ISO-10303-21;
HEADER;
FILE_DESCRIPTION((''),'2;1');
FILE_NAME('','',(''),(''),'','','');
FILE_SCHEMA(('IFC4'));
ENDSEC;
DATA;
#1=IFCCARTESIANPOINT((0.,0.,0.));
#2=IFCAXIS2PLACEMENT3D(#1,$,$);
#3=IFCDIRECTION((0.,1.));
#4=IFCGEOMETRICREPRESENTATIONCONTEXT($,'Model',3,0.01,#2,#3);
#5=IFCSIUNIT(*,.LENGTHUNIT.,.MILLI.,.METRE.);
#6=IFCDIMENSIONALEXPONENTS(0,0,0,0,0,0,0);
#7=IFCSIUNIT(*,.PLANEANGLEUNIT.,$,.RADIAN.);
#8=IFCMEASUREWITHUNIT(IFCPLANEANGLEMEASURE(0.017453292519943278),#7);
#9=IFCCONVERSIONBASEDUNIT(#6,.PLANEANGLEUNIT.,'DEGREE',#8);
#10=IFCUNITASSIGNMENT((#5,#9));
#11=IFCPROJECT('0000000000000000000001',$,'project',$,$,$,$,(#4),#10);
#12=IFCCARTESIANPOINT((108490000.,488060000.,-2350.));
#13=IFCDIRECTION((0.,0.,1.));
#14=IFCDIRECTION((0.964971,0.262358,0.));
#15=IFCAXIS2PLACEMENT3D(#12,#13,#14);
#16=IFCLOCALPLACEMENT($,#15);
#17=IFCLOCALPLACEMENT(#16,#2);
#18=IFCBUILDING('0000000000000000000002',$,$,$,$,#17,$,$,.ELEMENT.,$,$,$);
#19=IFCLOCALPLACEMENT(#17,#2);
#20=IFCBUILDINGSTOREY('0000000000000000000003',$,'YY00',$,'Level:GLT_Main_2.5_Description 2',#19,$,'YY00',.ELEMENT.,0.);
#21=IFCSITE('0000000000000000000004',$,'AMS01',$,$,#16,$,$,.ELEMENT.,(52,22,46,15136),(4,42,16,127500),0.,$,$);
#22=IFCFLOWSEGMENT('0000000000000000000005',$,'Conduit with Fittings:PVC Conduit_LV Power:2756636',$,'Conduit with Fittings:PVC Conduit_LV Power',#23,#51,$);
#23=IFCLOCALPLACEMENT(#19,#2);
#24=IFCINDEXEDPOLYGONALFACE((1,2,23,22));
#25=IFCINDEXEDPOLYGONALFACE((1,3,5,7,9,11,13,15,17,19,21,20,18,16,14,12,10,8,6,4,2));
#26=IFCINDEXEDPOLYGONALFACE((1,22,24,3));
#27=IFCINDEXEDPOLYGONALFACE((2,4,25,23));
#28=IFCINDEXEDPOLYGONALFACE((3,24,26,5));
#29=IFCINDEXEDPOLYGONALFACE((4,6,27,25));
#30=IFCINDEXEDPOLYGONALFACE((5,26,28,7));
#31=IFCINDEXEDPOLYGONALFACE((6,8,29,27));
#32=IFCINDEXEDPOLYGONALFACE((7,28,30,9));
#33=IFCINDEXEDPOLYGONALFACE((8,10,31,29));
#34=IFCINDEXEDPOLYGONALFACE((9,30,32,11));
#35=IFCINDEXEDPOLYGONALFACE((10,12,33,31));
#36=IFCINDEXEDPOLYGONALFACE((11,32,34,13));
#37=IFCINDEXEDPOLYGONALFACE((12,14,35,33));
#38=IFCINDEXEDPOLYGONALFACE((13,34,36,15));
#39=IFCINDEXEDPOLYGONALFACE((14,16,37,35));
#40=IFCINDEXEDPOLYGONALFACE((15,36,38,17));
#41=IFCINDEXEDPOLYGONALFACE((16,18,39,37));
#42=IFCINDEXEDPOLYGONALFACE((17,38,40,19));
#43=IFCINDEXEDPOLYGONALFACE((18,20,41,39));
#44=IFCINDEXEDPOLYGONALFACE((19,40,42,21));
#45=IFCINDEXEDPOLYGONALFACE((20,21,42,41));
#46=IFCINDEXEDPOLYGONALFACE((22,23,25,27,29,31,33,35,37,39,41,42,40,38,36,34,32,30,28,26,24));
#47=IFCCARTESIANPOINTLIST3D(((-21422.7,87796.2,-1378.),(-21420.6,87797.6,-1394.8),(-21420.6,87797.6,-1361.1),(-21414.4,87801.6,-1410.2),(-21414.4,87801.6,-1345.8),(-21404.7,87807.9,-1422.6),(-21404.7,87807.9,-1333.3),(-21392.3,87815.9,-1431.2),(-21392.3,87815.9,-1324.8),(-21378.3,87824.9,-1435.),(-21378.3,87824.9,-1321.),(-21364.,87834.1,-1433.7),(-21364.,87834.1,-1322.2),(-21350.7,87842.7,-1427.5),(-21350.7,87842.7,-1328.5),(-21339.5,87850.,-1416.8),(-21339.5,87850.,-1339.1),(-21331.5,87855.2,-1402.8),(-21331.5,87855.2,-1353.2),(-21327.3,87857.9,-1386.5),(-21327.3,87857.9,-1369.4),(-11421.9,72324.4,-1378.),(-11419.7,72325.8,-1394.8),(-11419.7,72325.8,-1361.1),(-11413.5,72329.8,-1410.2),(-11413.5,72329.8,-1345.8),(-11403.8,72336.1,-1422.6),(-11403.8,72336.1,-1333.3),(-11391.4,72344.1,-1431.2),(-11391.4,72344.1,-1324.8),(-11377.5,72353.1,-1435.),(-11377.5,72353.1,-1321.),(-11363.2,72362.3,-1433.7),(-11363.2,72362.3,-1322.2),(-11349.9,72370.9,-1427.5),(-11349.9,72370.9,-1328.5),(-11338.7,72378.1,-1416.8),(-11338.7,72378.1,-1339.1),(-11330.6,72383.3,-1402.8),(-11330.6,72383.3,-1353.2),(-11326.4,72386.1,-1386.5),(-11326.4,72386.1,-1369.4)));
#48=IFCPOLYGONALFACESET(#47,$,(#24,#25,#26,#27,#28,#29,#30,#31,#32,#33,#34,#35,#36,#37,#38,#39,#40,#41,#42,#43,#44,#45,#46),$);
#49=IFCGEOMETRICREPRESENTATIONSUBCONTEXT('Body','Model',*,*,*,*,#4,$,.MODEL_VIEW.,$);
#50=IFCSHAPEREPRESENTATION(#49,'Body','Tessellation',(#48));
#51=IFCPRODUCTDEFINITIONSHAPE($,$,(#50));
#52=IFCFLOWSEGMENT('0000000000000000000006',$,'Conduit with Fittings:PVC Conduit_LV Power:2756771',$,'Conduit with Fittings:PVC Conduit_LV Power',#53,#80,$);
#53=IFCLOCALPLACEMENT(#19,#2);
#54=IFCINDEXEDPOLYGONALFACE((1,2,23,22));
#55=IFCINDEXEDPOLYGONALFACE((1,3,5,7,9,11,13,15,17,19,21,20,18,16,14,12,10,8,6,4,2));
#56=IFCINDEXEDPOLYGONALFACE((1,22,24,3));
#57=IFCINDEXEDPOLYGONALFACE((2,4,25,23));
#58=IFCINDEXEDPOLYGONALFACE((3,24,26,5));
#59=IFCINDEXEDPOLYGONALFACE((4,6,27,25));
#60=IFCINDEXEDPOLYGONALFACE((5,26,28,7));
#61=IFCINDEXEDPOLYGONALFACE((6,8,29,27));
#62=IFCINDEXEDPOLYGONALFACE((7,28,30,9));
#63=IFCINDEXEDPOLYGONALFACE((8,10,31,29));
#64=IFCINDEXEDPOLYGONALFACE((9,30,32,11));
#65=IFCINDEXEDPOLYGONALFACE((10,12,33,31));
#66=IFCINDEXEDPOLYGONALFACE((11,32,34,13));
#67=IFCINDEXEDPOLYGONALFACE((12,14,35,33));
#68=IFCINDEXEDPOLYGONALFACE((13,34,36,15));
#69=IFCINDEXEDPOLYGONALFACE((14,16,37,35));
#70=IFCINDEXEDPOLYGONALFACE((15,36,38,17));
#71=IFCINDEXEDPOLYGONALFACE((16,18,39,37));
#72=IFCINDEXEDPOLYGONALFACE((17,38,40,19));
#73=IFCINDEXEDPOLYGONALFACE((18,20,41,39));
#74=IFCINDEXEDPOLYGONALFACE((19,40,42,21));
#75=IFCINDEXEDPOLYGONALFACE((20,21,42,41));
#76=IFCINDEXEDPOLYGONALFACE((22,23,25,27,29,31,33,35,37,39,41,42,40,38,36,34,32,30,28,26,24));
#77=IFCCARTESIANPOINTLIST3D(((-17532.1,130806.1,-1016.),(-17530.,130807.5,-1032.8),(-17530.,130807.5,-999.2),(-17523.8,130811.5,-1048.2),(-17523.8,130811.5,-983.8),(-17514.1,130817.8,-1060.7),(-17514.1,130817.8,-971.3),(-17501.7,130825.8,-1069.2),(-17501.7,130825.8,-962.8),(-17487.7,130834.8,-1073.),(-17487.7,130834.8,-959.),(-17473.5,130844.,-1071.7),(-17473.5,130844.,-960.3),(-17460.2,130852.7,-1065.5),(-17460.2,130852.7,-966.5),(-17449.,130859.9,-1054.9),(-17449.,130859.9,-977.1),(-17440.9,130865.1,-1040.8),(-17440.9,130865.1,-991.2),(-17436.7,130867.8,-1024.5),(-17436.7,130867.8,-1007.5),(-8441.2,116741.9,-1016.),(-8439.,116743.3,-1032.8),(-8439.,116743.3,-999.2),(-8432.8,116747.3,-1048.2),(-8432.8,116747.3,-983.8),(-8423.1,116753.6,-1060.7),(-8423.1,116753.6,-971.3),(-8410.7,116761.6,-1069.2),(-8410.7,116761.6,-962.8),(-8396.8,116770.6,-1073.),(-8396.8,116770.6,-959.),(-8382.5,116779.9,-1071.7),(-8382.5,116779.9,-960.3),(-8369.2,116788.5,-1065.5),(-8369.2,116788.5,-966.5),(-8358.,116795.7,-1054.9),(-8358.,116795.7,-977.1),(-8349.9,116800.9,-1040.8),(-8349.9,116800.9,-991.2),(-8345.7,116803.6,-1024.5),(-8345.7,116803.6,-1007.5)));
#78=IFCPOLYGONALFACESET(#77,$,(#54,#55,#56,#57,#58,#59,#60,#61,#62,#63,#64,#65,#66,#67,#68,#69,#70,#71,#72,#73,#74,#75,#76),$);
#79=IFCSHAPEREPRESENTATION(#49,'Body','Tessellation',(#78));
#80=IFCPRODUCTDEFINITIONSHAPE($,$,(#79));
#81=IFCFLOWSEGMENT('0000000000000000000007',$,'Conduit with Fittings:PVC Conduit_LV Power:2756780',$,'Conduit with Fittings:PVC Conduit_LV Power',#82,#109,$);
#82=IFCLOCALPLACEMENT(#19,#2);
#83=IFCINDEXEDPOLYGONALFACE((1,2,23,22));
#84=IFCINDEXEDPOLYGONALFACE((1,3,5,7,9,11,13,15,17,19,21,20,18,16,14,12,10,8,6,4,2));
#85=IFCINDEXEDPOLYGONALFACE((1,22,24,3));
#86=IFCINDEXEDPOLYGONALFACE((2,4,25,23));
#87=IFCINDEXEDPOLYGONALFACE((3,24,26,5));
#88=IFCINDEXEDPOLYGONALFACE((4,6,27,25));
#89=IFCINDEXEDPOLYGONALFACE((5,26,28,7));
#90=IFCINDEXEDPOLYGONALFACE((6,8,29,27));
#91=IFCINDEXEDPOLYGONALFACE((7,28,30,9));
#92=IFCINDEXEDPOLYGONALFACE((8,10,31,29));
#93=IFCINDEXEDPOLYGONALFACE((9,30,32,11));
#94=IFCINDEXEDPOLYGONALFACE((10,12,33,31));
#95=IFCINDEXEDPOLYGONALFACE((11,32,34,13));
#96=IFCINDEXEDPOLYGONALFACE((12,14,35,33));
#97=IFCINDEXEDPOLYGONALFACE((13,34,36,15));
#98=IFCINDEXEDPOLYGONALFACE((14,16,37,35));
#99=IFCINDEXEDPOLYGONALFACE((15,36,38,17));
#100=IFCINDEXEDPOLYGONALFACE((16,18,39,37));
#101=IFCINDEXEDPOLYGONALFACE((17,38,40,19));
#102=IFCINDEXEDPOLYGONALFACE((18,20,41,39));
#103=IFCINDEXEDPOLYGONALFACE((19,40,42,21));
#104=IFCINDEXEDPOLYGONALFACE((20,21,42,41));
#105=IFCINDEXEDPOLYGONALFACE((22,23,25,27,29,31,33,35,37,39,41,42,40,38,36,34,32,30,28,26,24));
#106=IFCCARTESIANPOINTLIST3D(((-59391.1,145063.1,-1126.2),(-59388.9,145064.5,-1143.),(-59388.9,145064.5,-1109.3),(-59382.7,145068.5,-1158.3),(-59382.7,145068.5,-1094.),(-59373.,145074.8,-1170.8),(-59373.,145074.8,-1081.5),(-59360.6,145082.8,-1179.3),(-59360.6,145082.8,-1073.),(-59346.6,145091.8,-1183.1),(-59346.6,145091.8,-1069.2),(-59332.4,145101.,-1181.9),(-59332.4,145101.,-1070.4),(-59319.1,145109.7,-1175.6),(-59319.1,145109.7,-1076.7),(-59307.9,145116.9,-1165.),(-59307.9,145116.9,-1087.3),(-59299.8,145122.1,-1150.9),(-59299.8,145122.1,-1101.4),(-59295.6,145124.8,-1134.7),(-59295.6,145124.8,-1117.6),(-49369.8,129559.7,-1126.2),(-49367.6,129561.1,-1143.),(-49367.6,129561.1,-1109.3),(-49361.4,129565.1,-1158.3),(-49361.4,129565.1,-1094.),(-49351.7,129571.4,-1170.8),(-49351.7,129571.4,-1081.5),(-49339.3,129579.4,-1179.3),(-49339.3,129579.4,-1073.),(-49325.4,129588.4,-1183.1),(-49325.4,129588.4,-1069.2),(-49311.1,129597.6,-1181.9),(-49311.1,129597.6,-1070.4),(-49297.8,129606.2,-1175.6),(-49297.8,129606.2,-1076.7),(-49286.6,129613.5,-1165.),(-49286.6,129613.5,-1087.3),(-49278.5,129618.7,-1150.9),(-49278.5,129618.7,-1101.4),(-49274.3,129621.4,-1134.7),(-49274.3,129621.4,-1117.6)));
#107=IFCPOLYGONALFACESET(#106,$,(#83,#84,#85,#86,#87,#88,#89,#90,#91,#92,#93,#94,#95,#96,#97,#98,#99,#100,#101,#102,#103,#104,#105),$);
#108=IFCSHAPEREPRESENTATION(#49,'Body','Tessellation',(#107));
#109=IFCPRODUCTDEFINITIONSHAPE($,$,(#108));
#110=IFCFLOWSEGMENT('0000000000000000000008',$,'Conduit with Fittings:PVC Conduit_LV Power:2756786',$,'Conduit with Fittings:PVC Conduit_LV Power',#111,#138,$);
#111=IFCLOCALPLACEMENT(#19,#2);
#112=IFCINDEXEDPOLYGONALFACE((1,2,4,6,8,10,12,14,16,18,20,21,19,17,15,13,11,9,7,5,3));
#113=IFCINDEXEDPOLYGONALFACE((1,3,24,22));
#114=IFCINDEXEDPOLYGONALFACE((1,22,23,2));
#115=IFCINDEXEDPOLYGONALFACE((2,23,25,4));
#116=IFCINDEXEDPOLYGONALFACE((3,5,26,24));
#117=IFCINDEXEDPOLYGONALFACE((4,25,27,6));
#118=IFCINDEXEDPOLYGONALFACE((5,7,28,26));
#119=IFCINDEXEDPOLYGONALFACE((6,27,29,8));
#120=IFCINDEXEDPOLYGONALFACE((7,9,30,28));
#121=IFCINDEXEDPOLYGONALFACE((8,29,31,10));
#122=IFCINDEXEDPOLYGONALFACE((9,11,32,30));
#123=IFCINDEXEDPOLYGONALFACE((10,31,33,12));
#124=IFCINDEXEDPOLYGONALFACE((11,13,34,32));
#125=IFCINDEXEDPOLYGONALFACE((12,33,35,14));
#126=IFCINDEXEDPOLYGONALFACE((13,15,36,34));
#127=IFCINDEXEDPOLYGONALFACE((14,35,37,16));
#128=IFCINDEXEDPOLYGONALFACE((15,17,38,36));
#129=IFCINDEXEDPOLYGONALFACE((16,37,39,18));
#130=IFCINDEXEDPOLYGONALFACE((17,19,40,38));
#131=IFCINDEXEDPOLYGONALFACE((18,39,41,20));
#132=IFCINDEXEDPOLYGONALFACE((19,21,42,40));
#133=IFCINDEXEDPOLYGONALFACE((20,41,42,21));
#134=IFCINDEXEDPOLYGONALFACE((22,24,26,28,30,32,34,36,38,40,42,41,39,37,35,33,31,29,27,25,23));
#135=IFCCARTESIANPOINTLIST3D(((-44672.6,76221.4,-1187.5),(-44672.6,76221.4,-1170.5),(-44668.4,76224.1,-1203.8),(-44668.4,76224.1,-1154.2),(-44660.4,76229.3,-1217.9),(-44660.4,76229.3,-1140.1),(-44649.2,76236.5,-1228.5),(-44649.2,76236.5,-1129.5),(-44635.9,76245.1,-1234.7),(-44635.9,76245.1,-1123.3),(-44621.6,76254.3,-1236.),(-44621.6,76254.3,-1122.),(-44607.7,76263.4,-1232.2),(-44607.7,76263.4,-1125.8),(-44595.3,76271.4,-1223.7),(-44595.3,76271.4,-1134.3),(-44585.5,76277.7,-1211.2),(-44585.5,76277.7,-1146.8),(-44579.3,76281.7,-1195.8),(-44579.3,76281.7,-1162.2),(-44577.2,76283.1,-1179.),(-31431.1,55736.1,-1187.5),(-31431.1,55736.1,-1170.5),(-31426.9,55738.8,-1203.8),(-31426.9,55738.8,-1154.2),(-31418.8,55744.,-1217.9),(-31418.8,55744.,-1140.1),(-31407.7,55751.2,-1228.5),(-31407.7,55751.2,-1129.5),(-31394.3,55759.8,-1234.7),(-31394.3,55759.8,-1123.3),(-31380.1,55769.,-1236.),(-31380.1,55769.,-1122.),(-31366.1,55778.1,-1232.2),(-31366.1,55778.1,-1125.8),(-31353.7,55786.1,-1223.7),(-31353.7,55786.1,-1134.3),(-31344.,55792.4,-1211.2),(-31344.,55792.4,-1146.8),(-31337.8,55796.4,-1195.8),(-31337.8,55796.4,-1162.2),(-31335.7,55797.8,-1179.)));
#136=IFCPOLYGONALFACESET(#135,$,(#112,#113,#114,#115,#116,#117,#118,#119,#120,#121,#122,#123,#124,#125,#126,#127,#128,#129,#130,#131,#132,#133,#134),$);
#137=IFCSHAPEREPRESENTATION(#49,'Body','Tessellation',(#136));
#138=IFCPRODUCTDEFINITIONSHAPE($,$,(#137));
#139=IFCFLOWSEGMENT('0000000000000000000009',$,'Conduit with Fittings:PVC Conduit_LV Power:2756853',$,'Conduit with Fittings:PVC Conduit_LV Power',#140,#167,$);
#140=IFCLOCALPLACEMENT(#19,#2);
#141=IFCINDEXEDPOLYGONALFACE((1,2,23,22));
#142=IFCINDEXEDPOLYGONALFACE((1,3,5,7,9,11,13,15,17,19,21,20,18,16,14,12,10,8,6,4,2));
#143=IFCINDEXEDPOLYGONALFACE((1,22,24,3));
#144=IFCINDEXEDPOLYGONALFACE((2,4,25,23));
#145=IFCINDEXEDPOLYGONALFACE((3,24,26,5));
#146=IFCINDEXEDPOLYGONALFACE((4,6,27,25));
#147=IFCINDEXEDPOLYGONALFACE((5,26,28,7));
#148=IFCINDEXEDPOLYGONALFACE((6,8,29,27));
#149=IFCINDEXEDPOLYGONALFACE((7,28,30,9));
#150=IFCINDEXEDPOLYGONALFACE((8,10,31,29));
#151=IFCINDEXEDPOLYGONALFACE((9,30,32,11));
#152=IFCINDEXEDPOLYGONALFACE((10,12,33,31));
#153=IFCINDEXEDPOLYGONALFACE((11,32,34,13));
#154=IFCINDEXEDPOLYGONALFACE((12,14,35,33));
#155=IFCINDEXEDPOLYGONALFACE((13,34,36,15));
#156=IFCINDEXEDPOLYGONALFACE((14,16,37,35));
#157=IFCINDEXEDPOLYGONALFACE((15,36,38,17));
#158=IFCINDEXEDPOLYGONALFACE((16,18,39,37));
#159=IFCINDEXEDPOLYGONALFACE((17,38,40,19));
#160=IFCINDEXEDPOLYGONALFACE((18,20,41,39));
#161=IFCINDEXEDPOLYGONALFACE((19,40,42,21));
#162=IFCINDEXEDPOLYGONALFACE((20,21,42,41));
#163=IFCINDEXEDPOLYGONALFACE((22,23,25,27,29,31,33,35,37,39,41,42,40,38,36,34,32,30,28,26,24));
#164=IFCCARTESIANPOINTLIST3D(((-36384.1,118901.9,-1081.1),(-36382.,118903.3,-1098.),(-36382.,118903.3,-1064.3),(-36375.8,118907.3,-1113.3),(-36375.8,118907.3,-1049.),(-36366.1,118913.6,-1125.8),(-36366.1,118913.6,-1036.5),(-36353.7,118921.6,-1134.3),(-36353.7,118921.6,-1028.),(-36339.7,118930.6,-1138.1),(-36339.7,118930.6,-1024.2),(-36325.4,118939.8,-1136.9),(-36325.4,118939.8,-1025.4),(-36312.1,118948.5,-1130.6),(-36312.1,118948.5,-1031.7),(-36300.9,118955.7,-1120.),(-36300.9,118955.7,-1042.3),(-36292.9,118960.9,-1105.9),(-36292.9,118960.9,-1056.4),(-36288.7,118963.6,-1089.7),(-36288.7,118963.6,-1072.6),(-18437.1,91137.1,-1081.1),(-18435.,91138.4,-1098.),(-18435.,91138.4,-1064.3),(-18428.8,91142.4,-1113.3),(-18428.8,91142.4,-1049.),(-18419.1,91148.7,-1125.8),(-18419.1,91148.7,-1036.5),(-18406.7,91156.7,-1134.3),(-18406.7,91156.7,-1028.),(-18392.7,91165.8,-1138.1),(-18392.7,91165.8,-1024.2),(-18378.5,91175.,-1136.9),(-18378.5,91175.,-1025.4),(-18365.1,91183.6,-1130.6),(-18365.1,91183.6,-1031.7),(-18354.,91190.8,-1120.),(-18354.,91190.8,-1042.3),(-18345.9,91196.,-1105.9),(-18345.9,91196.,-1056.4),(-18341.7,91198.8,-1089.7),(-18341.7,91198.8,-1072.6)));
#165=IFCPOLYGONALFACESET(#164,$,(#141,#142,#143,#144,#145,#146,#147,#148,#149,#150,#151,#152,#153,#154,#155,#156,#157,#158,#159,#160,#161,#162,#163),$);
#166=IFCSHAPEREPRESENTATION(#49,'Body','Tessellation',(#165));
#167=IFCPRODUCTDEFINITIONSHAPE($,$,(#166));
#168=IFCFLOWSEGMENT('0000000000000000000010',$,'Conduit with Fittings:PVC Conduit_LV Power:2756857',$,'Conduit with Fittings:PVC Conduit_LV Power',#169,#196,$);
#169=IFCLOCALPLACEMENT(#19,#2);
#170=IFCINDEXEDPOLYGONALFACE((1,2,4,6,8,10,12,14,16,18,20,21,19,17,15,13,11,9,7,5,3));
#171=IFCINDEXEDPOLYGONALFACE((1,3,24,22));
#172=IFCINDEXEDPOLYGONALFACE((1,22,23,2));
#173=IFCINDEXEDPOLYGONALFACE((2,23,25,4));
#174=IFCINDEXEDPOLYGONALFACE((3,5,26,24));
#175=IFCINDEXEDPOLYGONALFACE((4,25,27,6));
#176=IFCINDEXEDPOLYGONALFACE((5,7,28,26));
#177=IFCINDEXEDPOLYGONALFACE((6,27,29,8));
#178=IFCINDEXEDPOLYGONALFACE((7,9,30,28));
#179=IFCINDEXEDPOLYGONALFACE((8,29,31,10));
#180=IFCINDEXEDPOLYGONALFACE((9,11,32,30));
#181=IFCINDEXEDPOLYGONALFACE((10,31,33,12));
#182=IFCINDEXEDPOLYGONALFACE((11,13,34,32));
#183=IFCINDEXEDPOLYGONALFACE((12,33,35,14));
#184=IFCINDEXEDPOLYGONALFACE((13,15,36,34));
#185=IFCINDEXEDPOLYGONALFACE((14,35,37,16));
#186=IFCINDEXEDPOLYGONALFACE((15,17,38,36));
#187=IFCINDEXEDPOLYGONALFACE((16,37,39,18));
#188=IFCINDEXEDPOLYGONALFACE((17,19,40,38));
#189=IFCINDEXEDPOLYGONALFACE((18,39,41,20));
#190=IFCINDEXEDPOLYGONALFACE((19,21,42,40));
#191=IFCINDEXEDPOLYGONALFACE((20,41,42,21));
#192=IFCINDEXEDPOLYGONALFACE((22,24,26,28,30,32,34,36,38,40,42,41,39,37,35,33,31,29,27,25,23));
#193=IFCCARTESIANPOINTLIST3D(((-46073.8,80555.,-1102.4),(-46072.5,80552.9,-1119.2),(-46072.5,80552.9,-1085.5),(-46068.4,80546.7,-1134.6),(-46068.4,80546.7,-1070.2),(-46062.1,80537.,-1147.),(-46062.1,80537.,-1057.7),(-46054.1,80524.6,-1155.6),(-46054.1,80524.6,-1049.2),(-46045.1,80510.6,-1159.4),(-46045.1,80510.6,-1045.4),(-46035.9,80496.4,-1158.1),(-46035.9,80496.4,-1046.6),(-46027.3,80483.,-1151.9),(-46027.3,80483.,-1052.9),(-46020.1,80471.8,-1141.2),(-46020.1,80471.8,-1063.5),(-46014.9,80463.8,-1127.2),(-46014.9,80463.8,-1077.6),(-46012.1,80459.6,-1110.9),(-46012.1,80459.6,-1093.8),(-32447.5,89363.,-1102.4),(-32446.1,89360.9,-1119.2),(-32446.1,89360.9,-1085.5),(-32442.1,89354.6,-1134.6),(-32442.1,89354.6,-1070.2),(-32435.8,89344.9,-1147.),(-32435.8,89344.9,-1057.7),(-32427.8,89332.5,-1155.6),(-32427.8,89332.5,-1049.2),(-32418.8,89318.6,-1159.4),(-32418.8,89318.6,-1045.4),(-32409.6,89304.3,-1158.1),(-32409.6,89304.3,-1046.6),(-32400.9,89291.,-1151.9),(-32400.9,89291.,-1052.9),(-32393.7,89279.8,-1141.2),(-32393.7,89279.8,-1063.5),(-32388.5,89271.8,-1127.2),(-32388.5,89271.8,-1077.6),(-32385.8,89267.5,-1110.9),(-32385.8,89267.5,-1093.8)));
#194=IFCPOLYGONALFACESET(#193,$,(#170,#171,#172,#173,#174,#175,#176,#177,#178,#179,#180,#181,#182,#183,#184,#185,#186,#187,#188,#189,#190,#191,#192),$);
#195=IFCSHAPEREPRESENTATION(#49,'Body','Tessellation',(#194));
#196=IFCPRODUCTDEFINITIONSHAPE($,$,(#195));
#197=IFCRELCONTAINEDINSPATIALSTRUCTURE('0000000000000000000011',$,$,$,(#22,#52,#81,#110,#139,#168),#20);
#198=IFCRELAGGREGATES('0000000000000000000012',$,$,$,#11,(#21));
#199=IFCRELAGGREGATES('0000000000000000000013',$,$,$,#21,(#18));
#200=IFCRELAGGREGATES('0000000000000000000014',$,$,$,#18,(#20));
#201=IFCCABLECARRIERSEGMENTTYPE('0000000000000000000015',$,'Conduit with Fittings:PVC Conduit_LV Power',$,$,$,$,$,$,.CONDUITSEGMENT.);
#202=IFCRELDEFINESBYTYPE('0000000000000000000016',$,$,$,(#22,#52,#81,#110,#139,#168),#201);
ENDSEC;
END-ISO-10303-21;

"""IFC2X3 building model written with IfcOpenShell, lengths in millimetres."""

from ifc_helpers import new_model, entity, si_unit, converted_unit, direction, frame, frame_2d, origin, origin_2d_with_axis, place, context, subcontext, project, spatial, circle, extrude, type_object, element, save


model = new_model("IFC2X3")

# Units and contexts
model_context = context("Model", 3, precision=0.01, world=origin(), true_north=direction((0.0, 1.0)))
body_context = subcontext(model_context, "Body", "Model", "MODEL_VIEW")
ifc_project = project(units=[si_unit("LENGTHUNIT", "METRE", prefix="MILLI"), converted_unit("PLANEANGLEUNIT", "DEGREE", entity("IfcPlaneAngleMeasure", 0.017453292519943278), si_unit("PLANEANGLEUNIT", "RADIAN"), dimensions=[0, 0, 0, 0, 0, 0, 0])], contexts=[model_context])

# Site, building, storey
site_placement = place(None, frame((108490000.0, 488060000.0, -2350.0), z_axis=(0.0, 0.0, 1.0), x_axis=(0.964971, 0.262358, 0.0)))
site = spatial("IfcSite", under=ifc_project, at=site_placement, Name="AMS01", CompositionType="ELEMENT", RefLatitude=(52, 22, 46, 15136), RefLongitude=(4, 42, 16, 127500), RefElevation=0.0)
building_placement = place(site_placement, origin())
building = spatial("IfcBuilding", under=site, at=building_placement, CompositionType="ELEMENT")
storey_placement = place(building_placement, origin())
storey = spatial("IfcBuildingStorey", under=building, at=storey_placement, Name="YY00", ObjectType="Level:GLT_Main_2.5_Description 2", LongName="YY00", CompositionType="ELEMENT", Elevation=0.0)

# Flow segments
cable_carrier_segment_type = type_object("IfcCableCarrierSegmentType", Name="Conduit with Fittings:PVC Conduit_LV Power", PredefinedType="CONDUITSEGMENT")
flow_segment_1_placement = place(storey_placement, origin())
element("IfcFlowSegment", 1, at=flow_segment_1_placement, inside=storey, type_object=cable_carrier_segment_type, Name="Conduit with Fittings:PVC Conduit_LV Power:2756636", ObjectType="Conduit with Fittings:PVC Conduit_LV Power", context=body_context, shape_type="SweptSolid", body=[
    extrude(circle(Radius=57.2, at=origin_2d_with_axis()), frame((-21374.7, 87827.2, -1378.0), z_axis=(0.542856, -0.839826, 0.0), x_axis=(-0.839826, -0.542856, 0.0)), (0.0, 0.0, 1.0), 18422.7),
])
flow_segment_2_placement = place(storey_placement, origin())
element("IfcFlowSegment", 2, at=flow_segment_2_placement, inside=storey, type_object=cable_carrier_segment_type, Name="Conduit with Fittings:PVC Conduit_LV Power:2756771", ObjectType="Conduit with Fittings:PVC Conduit_LV Power", context=body_context, shape_type="SweptSolid", body=[
    extrude(circle(Radius=57.2, at=frame_2d((0.0, 0.0), x_axis=(1.0, 0.0))), frame((-8393.2, 116773.0, -1016.0), z_axis=(-0.542856, 0.839826, 0.0), x_axis=(-0.839826, -0.542856, 0.0)), (0.0, 0.0, 1.0), 16746.6),
])
flow_segment_3_placement = place(storey_placement, origin())
element("IfcFlowSegment", 3, at=flow_segment_3_placement, inside=storey, type_object=cable_carrier_segment_type, Name="Conduit with Fittings:PVC Conduit_LV Power:2756780", ObjectType="Conduit with Fittings:PVC Conduit_LV Power", context=body_context, shape_type="SweptSolid", body=[
    extrude(circle(Radius=57.2, at=frame_2d((0.0, 0.0), x_axis=(1.0, 0.0))), frame((-49321.8, 129590.7, -1126.2), z_axis=(-0.542856, 0.839826, 0.0), x_axis=(-0.839826, -0.542856, 0.0)), (0.0, 0.0, 1.0), 18460.3),
])
flow_segment_4_placement = place(storey_placement, origin())
element("IfcFlowSegment", 4, at=flow_segment_4_placement, inside=storey, type_object=cable_carrier_segment_type, Name="Conduit with Fittings:PVC Conduit_LV Power:2756786", ObjectType="Conduit with Fittings:PVC Conduit_LV Power", context=body_context, shape_type="SweptSolid", body=[
    extrude(circle(Radius=57.2, at=frame_2d((0.0, 0.0), x_axis=(1.0, 0.0))), frame((-31383.7, 55766.7, -1179.0), z_axis=(-0.542856, 0.839826, 0.0), x_axis=(0.839826, 0.542856, 0.0)), (0.0, 0.0, 1.0), 24392.3),
])
flow_segment_5_placement = place(storey_placement, origin())
element("IfcFlowSegment", 5, at=flow_segment_5_placement, inside=storey, type_object=cable_carrier_segment_type, Name="Conduit with Fittings:PVC Conduit_LV Power:2756853", ObjectType="Conduit with Fittings:PVC Conduit_LV Power", context=body_context, shape_type="SweptSolid", body=[
    extrude(circle(Radius=57.2, at=frame_2d((0.0, 0.0), x_axis=(1.0, 0.0))), frame((-18389.1, 91168.1, -1081.1), z_axis=(-0.542856, 0.839826, 0.0), x_axis=(-0.839826, -0.542856, 0.0)), (0.0, 0.0, 1.0), 33060.3),
])
flow_segment_6_placement = place(storey_placement, origin())
element("IfcFlowSegment", 6, at=flow_segment_6_placement, inside=storey, type_object=cable_carrier_segment_type, Name="Conduit with Fittings:PVC Conduit_LV Power:2756857", ObjectType="Conduit with Fittings:PVC Conduit_LV Power", context=body_context, shape_type="SweptSolid", body=[
    extrude(circle(Radius=57.2, at=frame_2d((0.0, 0.0), x_axis=(1.0, 0.0))), frame((-46042.8, 80507.0, -1102.4), z_axis=(0.839826, 0.542856, 0.0), x_axis=(-0.542856, 0.839826, 0.0)), (0.0, 0.0, 1.0), 16225.2),
])

save(model, "model.ifc")
